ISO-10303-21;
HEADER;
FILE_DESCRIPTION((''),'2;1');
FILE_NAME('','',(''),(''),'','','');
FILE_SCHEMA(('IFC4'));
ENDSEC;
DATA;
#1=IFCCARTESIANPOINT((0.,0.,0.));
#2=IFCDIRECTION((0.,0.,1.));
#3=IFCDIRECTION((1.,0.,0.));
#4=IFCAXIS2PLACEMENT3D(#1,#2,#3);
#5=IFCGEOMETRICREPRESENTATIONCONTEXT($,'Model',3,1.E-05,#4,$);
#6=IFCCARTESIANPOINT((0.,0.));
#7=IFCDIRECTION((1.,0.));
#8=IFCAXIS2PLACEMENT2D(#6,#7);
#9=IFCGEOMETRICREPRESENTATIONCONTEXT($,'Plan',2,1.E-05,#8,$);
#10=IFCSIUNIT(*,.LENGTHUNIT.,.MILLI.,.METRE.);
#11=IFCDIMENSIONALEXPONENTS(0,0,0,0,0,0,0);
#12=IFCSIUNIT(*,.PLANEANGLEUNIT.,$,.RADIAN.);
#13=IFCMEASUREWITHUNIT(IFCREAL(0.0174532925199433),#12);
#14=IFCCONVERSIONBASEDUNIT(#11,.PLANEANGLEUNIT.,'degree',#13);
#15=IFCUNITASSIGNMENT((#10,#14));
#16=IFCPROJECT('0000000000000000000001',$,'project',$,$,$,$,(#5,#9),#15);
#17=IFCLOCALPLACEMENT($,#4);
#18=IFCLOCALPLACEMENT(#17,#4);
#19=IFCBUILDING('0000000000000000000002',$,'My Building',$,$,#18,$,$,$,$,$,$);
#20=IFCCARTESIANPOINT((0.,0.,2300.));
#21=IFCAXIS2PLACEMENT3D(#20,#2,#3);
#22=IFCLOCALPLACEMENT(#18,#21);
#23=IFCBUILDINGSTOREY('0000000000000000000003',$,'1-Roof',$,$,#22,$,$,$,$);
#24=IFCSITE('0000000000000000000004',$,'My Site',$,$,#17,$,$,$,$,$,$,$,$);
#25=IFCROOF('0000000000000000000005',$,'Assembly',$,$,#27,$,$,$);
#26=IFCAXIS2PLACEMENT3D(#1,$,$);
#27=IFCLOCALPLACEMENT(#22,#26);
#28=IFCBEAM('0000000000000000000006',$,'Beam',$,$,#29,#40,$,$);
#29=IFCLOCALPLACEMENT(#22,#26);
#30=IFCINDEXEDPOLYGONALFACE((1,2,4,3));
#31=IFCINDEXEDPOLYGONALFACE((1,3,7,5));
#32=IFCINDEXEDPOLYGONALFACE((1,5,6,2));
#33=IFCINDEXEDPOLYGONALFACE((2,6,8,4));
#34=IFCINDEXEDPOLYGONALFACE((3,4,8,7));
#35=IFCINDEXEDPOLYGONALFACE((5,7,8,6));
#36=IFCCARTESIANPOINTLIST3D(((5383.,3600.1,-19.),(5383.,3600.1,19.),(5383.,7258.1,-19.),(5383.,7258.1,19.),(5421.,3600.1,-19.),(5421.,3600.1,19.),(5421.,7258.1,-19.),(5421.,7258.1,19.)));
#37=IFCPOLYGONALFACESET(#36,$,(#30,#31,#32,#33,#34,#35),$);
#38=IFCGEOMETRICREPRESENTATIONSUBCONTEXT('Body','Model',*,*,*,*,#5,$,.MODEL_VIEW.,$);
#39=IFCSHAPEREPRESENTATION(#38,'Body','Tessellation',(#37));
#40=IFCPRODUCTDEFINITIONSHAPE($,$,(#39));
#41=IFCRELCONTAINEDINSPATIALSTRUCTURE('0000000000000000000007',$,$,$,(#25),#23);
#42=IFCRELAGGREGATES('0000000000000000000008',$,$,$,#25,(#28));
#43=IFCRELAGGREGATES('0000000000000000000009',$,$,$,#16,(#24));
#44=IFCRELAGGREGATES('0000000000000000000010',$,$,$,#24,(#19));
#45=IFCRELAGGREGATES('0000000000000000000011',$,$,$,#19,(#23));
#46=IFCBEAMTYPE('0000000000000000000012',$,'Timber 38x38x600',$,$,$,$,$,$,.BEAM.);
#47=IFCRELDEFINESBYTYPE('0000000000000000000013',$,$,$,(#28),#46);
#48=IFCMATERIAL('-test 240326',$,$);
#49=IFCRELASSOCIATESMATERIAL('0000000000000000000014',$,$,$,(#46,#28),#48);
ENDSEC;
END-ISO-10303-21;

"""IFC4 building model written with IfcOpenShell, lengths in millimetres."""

from ifc_helpers import new_model, entity, si_unit, converted_unit, frame, origin_with_axes, origin_2d_with_axis, place, context, subcontext, project, spatial, rectangle, extrude, material, material_profile, profile_set, profile_usage, type_object, element, aggregate, save


model = new_model("IFC4")

# Units and contexts
model_context = context("Model", 3, precision=1e-05, world=origin_with_axes())
plan_context = context("Plan", 2, precision=1e-05, world=origin_2d_with_axis())
body_context = subcontext(model_context, "Body", "Model", "MODEL_VIEW")
ifc_project = project(units=[si_unit("LENGTHUNIT", "METRE", prefix="MILLI"), converted_unit("PLANEANGLEUNIT", "degree", entity("IfcReal", 0.0174532925199433), si_unit("PLANEANGLEUNIT", "RADIAN"), dimensions=[0, 0, 0, 0, 0, 0, 0])], contexts=[model_context, plan_context])

# Site, building, storey
site_placement = place(None, origin_with_axes())
site = spatial("IfcSite", under=ifc_project, at=site_placement, Name="My Site")
building_placement = place(site_placement, origin_with_axes())
building = spatial("IfcBuilding", under=site, at=building_placement, Name="My Building")
storey_placement = place(building_placement, frame((0.0, 0.0, 2300.0), z_axis=(0.0, 0.0, 1.0), x_axis=(1.0, 0.0, 0.0)))
storey = spatial("IfcBuildingStorey", under=building, at=storey_placement, Name="1-Roof")

# Roof, beam
roof_placement = place(storey_placement, frame((5390.9, 3600.1, 19.2), z_axis=(0.0, 0.0, 1.0), x_axis=(1.0, 0.0, 0.0)))
roof = element("IfcRoof", 1, at=roof_placement, inside=storey, Name="Assembly")
ifc_material_1 = material(Name="-test 240326")
ifc_material_profile_1 = material_profile(ifc_material_1, rectangle(XDim=38.0, YDim=38.0))
ifc_profile_set_1 = profile_set([ifc_material_profile_1])
beam_type_1 = type_object("IfcBeamType", Name="Timber 38x38x600", PredefinedType="BEAM", material=ifc_profile_set_1)
ifc_profile_usage_1 = profile_usage(ifc_profile_set_1, cardinal=5)
beam_1_placement = place(roof_placement, frame((11.2, 0.0, -19.2), z_axis=(0.0, 1.0, 0.0), x_axis=(-1.0, 0.0, 0.0)))
beam_1 = element("IfcBeam", 2, at=beam_1_placement, type_object=beam_type_1, material=ifc_profile_usage_1, Name="Beam", context=body_context, shape_type="SweptSolid", body=[
    extrude(rectangle(XDim=38.0, YDim=38.0), origin_with_axes(), (0.0, 0.0, 1.0), 3658.0),
])
aggregate(roof, [beam_1])

save(model, "model.ifc")
